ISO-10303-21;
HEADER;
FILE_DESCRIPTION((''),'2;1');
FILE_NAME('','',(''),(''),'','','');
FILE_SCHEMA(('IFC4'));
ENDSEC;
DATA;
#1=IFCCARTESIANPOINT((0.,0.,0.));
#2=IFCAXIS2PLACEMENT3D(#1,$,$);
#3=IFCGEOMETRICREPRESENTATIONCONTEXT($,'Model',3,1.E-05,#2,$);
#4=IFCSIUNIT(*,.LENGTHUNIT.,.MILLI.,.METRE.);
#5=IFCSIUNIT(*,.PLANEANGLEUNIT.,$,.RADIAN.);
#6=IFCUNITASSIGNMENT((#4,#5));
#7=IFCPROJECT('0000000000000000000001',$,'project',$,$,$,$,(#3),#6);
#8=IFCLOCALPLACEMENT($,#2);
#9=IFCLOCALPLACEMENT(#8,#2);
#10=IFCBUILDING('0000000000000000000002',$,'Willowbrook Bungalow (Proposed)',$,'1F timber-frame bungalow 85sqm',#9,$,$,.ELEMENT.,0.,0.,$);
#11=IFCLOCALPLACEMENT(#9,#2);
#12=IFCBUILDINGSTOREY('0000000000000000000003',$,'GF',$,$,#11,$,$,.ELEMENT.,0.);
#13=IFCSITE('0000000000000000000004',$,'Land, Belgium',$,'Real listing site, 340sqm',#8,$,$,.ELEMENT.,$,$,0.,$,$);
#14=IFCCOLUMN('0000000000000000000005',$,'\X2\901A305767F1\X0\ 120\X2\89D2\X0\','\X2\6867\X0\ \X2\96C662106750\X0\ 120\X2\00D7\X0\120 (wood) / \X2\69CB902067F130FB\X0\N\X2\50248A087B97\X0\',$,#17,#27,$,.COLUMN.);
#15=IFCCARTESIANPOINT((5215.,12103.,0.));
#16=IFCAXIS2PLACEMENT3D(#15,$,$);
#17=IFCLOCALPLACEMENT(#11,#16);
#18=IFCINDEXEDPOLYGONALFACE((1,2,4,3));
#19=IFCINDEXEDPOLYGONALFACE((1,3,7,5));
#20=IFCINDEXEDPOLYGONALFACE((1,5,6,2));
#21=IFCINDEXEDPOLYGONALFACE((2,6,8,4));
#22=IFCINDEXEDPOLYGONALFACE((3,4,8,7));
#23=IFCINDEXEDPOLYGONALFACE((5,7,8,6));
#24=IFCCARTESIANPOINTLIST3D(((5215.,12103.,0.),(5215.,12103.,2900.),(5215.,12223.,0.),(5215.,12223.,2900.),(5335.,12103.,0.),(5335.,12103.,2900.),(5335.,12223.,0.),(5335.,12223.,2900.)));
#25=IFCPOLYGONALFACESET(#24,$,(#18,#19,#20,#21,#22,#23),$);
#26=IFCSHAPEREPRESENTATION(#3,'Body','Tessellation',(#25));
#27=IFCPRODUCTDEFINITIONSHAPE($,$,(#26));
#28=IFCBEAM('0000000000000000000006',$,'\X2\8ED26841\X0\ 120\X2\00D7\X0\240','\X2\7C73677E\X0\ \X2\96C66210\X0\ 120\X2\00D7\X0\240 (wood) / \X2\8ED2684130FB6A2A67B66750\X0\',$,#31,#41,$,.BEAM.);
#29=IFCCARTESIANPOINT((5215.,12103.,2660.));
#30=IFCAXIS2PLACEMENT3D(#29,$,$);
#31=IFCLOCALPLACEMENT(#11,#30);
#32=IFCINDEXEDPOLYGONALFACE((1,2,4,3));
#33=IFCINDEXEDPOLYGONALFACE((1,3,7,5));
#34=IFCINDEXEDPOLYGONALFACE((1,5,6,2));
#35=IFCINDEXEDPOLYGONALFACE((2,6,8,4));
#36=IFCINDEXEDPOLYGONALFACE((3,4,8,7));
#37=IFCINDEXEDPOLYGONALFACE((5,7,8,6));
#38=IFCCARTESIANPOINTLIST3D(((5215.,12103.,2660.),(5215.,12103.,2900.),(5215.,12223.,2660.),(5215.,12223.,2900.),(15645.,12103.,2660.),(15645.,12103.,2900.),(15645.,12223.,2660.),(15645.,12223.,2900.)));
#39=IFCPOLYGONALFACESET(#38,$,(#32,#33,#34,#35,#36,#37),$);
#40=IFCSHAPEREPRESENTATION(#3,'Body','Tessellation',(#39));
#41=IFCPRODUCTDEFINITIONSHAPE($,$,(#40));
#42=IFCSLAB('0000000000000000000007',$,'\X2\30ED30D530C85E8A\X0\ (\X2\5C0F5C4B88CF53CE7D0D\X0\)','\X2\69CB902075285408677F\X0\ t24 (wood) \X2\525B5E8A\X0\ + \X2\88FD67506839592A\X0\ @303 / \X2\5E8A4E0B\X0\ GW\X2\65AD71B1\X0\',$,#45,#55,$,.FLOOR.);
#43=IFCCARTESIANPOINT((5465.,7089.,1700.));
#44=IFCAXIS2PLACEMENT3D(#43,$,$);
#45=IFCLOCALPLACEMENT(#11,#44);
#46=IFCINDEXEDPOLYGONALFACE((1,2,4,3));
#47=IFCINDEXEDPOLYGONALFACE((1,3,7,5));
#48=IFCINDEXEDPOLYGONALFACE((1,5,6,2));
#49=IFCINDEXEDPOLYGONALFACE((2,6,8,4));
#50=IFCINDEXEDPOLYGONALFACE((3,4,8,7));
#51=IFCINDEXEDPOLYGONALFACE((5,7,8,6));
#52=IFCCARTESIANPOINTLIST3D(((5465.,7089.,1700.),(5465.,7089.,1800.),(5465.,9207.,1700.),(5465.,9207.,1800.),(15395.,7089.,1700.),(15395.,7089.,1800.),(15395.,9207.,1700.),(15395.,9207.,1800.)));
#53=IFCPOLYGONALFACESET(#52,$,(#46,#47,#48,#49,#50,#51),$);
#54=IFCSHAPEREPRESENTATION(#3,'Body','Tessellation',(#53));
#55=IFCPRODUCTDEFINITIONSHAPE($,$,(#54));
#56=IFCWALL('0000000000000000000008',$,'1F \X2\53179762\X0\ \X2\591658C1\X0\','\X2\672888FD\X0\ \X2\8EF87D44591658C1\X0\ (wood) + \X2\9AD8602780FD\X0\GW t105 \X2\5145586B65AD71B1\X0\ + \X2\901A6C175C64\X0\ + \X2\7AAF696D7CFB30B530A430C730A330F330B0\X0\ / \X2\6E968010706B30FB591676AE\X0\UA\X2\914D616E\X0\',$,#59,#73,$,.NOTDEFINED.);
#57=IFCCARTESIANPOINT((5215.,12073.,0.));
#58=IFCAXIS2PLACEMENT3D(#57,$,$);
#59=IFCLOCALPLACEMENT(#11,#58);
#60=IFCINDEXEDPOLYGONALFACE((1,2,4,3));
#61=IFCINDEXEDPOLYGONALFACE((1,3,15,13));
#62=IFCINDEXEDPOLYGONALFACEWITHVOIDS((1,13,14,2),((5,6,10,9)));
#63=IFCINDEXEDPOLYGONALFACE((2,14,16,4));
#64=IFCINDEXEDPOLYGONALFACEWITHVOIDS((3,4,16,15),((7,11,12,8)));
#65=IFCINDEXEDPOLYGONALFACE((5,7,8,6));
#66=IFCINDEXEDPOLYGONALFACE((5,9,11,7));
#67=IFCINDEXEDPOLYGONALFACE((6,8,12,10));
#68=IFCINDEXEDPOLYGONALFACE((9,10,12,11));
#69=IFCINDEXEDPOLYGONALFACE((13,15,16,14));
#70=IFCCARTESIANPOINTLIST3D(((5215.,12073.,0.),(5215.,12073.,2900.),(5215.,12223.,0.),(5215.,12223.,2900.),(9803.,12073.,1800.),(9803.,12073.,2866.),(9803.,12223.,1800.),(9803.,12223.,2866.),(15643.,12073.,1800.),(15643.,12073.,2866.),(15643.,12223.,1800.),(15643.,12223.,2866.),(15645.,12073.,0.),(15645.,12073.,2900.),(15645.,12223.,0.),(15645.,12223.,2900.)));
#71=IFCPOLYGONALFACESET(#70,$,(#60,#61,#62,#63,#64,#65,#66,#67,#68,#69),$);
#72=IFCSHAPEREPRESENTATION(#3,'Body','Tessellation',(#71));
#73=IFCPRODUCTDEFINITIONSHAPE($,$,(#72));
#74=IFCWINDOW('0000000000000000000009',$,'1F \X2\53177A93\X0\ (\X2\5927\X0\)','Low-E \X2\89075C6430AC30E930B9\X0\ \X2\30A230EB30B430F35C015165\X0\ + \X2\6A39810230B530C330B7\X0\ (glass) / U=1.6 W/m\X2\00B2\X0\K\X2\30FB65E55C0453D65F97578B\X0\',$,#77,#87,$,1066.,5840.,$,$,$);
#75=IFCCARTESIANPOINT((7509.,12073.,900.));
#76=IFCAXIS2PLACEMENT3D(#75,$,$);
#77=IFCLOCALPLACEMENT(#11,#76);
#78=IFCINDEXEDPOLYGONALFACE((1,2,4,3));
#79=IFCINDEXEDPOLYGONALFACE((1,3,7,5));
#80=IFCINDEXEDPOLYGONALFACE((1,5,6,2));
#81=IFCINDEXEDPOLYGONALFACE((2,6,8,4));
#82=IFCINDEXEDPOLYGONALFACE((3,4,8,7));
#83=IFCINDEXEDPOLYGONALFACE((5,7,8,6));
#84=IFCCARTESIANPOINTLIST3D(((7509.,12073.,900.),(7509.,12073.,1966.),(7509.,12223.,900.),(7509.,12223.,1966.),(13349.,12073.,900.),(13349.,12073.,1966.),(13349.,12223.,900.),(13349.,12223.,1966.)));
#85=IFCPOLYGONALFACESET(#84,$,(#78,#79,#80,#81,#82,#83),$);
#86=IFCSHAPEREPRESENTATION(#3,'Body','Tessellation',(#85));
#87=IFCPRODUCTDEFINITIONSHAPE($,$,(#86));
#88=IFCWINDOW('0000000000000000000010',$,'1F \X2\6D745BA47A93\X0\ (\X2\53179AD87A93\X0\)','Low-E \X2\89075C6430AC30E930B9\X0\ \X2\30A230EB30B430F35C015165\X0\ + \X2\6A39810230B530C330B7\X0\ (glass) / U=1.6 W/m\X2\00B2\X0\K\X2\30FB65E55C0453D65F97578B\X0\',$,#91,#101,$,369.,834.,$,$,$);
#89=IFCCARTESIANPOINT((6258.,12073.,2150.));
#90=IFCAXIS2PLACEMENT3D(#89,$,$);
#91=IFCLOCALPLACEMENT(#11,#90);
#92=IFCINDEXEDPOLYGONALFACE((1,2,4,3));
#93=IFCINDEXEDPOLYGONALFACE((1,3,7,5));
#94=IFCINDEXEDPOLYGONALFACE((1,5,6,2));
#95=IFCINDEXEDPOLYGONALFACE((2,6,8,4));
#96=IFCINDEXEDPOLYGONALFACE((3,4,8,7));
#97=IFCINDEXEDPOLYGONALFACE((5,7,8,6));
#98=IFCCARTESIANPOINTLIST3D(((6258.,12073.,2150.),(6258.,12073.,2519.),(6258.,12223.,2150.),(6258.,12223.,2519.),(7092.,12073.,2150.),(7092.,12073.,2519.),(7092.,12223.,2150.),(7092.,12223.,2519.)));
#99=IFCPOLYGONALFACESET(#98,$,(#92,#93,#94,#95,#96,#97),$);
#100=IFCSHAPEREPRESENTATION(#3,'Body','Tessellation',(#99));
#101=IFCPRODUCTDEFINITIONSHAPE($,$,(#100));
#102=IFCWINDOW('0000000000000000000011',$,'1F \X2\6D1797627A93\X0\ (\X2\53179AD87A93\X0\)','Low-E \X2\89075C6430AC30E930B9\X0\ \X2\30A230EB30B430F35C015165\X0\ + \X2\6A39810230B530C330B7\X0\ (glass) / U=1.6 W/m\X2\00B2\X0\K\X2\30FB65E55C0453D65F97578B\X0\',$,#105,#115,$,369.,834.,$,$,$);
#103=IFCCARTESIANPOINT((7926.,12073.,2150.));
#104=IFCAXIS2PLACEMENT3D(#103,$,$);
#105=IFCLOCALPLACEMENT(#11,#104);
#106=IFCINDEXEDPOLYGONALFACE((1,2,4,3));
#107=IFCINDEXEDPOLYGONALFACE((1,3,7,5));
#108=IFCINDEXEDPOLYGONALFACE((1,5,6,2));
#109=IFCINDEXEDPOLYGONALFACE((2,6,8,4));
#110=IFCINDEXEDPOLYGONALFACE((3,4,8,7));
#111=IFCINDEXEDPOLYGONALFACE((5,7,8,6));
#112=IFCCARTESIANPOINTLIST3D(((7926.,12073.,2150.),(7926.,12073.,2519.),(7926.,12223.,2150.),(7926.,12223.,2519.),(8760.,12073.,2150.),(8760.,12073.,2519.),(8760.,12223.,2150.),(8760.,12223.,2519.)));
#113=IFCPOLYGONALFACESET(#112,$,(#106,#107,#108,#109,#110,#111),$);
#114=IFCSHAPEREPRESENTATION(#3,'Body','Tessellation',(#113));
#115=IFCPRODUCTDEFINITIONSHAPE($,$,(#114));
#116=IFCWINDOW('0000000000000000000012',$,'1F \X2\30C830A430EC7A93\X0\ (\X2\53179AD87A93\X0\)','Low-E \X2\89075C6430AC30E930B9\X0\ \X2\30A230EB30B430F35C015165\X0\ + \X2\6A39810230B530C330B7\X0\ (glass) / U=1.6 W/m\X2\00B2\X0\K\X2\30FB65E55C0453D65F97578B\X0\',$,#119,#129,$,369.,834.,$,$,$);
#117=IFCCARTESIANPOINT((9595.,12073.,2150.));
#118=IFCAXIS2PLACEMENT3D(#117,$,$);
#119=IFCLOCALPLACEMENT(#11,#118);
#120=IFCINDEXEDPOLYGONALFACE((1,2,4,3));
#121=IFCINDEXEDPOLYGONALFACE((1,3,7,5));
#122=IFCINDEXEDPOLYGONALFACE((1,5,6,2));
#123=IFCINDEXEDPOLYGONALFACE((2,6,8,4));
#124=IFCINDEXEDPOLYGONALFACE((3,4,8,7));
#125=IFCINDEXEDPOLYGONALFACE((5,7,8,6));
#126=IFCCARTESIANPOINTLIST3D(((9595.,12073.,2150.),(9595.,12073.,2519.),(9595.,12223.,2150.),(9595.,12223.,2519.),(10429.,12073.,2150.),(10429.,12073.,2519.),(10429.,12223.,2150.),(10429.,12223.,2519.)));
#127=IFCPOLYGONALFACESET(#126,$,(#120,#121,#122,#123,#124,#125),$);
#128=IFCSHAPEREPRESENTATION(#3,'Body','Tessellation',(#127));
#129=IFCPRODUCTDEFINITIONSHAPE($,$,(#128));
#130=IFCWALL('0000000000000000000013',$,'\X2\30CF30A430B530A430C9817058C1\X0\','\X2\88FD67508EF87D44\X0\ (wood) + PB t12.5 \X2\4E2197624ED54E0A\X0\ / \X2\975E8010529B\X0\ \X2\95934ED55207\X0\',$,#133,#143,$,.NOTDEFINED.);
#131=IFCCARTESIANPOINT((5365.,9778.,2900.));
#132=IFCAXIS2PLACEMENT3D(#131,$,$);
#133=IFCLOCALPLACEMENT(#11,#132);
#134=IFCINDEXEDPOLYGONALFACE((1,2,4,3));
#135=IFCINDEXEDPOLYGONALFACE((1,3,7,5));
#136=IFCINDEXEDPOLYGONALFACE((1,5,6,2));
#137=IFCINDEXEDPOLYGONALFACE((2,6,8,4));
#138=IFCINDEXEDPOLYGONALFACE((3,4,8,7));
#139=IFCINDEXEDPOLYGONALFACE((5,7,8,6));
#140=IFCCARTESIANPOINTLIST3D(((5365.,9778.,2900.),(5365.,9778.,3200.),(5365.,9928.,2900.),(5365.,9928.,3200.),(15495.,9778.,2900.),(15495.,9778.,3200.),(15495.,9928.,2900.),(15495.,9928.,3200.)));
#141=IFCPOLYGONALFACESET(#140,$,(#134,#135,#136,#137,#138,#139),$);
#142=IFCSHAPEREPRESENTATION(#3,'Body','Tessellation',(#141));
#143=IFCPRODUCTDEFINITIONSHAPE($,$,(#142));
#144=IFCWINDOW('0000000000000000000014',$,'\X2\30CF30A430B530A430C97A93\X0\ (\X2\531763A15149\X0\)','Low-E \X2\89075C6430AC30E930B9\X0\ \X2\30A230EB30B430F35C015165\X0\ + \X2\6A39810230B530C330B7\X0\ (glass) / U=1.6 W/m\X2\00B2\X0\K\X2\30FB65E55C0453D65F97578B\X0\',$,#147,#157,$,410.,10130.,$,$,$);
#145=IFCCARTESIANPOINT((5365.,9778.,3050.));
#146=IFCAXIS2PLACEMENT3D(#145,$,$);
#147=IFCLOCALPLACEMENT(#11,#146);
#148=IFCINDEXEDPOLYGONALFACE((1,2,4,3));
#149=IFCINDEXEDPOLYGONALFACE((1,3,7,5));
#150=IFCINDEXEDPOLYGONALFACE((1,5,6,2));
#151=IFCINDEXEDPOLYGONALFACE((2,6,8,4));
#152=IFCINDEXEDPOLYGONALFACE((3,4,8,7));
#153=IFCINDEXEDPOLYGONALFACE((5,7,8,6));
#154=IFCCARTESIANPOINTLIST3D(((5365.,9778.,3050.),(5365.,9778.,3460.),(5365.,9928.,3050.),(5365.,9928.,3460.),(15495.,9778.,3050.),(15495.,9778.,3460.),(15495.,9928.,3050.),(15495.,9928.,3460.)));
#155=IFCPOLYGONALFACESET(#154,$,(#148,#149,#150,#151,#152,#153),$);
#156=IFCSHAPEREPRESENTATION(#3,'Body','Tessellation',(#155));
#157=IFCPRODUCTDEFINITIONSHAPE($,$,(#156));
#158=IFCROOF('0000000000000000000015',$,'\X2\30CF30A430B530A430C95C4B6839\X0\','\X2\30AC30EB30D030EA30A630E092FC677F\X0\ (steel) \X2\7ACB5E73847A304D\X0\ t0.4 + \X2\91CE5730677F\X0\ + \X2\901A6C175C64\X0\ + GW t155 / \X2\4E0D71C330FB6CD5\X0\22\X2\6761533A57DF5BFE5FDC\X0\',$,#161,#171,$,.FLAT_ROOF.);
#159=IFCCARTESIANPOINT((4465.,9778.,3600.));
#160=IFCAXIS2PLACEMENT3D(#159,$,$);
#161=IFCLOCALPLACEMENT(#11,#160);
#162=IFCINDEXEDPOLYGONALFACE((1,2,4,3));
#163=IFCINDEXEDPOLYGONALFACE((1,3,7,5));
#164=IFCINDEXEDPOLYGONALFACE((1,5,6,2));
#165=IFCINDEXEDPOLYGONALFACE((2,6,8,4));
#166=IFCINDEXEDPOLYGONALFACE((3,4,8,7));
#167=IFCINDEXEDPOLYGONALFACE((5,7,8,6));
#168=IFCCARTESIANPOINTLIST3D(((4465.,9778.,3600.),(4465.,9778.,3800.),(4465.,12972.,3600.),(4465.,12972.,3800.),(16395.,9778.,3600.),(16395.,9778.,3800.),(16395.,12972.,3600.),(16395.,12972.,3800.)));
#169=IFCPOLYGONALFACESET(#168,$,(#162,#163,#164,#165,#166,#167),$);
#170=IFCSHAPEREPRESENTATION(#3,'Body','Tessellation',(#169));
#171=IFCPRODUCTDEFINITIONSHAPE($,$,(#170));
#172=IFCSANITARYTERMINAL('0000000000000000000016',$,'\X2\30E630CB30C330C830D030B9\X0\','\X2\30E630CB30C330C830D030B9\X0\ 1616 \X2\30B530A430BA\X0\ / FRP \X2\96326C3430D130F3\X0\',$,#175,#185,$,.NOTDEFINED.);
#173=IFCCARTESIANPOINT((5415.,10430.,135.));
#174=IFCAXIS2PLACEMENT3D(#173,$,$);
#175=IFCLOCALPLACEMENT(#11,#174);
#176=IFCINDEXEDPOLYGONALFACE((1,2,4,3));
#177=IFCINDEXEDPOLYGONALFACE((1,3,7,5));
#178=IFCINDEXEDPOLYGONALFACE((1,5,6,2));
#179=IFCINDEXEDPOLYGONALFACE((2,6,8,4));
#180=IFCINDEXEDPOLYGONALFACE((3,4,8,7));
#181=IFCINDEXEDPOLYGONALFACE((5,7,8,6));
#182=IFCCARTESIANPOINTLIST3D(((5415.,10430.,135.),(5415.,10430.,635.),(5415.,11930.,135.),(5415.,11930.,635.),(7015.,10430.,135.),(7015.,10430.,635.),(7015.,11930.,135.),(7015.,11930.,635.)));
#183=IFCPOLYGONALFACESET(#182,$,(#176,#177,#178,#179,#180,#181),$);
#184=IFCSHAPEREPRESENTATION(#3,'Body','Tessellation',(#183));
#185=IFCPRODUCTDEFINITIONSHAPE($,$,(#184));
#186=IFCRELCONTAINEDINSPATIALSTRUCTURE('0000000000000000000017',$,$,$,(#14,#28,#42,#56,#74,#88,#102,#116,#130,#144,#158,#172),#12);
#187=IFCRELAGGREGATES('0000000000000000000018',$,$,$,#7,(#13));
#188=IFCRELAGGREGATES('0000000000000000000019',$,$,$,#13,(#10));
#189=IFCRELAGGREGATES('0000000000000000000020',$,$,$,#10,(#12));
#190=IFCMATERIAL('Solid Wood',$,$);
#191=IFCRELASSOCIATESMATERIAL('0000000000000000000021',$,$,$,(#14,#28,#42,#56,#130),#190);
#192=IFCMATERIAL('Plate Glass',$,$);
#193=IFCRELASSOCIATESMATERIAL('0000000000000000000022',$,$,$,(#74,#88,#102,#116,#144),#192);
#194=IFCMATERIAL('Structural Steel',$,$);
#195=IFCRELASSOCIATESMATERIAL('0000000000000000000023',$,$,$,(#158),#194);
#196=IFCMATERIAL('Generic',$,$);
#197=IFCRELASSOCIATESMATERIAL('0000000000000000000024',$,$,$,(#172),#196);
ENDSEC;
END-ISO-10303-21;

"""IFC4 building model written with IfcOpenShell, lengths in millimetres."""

from ifc_helpers import new_model, si_unit, frame, frame_2d, origin, place, context, project, spatial, rectangle, extrude, material, element, fill, save


model = new_model("IFC4")

# Units and contexts
model_context = context("Model", 3, precision=1e-05, world=origin())
ifc_project = project(units=[si_unit("LENGTHUNIT", "METRE", prefix="MILLI"), si_unit("PLANEANGLEUNIT", "RADIAN")], contexts=[model_context])

# Site, building, storey
site_placement = place(None, origin())
site = spatial("IfcSite", under=ifc_project, at=site_placement, Name="Land, Belgium", ObjectType="Real listing site, 340sqm", CompositionType="ELEMENT", RefElevation=0.0)
building_placement = place(site_placement, origin())
building = spatial("IfcBuilding", under=site, at=building_placement, Name="Willowbrook Bungalow (Proposed)", ObjectType="1F timber-frame bungalow 85sqm", CompositionType="ELEMENT", ElevationOfRefHeight=0.0, ElevationOfTerrain=0.0)
storey_placement = place(building_placement, origin())
storey = spatial("IfcBuildingStorey", under=building, at=storey_placement, Name="GF", CompositionType="ELEMENT", Elevation=0.0)

# Column
ifc_material_1 = material(Name="Solid Wood")
column_1_placement = place(storey_placement, frame((5215.0, 12103.0, 0.0)))
element("IfcColumn", 1, at=column_1_placement, inside=storey, material=ifc_material_1, Name="通し柱 120角", Description="桧 集成材 120×120 (wood) / 構造柱・N値計算", PredefinedType="COLUMN", context=model_context, shape_type="SweptSolid", body=[
    extrude(rectangle(XDim=120.0, YDim=120.0, at=frame_2d((60.0, 60.0))), frame((5215.0, 12103.0, 0.0)), (0.0, 0.0, 1.0), 2900.0),
])

# Beam
beam_1_placement = place(storey_placement, frame((5215.0, 12103.0, 2660.0)))
element("IfcBeam", 2, at=beam_1_placement, inside=storey, material=ifc_material_1, Name="軒桁 120×240", Description="米松 集成 120×240 (wood) / 軒桁・横架材", PredefinedType="BEAM", context=model_context, shape_type="SweptSolid", body=[
    extrude(rectangle(XDim=10430.0, YDim=120.0, at=frame_2d((5215.0, 60.0))), frame((5215.0, 12103.0, 2660.0)), (0.0, 0.0, 1.0), 240.0),
])

# Slab
slab_placement = place(storey_placement, frame((5465.0, 7089.0, 1700.0)))
element("IfcSlab", 3, at=slab_placement, inside=storey, material=ifc_material_1, Name="ロフト床 (小屋裏収納)", Description="構造用合板 t24 (wood) 剛床 + 製材根太 @303 / 床下 GW断熱", PredefinedType="FLOOR", context=model_context, shape_type="SweptSolid", body=[
    extrude(rectangle(XDim=9930.0, YDim=2118.0, at=frame_2d((4965.0, 1059.0))), frame((5465.0, 7089.0, 1700.0)), (0.0, 0.0, 1.0), 100.0),
])

# Wall, openings, windows
wall_1_placement = place(storey_placement, frame((5215.0, 12073.0, 0.0)))
wall_1 = element("IfcWall", 4, at=wall_1_placement, inside=storey, material=ifc_material_1, Name="1F 北面 外壁", Description="木製 軸組外壁 (wood) + 高性能GW t105 充填断熱 + 通気層 + 窯業系サイディング / 準耐火・外皮UA配慮", PredefinedType="NOTDEFINED", context=model_context, shape_type="SweptSolid", body=[
    extrude(rectangle(XDim=10430.0, YDim=150.0, at=frame_2d((5215.0, 75.0))), frame((5215.0, 12073.0, 0.0)), (0.0, 0.0, 1.0), 2900.0),
])
opening_1_placement = place(storey_placement, frame((7509.0, 12073.0, 900.0)))
opening_1 = element("IfcOpeningElement", 5, at=opening_1_placement, cuts=wall_1, PredefinedType="NOTDEFINED", context=model_context, shape_type="SweptSolid", body=[
    extrude(rectangle(XDim=5840.0, YDim=150.0, at=frame_2d((2920.0, 75.0))), frame((7509.0, 12073.0, 900.0)), (0.0, 0.0, 1.0), 1066.0),
])
opening_2_placement = place(storey_placement, frame((6258.0, 12073.0, 2150.0)))
opening_2 = element("IfcOpeningElement", 6, at=opening_2_placement, cuts=wall_1, PredefinedType="NOTDEFINED", context=model_context, shape_type="SweptSolid", body=[
    extrude(rectangle(XDim=834.0, YDim=150.0, at=frame_2d((417.0, 75.0))), frame((6258.0, 12073.0, 2150.0)), (0.0, 0.0, 1.0), 369.0),
])
opening_3_placement = place(storey_placement, frame((7926.0, 12073.0, 2150.0)))
opening_3 = element("IfcOpeningElement", 7, at=opening_3_placement, cuts=wall_1, PredefinedType="NOTDEFINED", context=model_context, shape_type="SweptSolid", body=[
    extrude(rectangle(XDim=834.0, YDim=150.0, at=frame_2d((417.0, 75.0))), frame((7926.0, 12073.0, 2150.0)), (0.0, 0.0, 1.0), 369.0),
])
opening_4_placement = place(storey_placement, frame((9595.0, 12073.0, 2150.0)))
opening_4 = element("IfcOpeningElement", 8, at=opening_4_placement, cuts=wall_1, PredefinedType="NOTDEFINED", context=model_context, shape_type="SweptSolid", body=[
    extrude(rectangle(XDim=834.0, YDim=150.0, at=frame_2d((417.0, 75.0))), frame((9595.0, 12073.0, 2150.0)), (0.0, 0.0, 1.0), 369.0),
])
ifc_material_2 = material(Name="Plate Glass")
window_1_placement = place(storey_placement, frame((7509.0, 12073.0, 900.0)))
window_1 = element("IfcWindow", 9, at=window_1_placement, inside=storey, material=ifc_material_2, Name="1F 北窓 (大)", Description="Low-E 複層ガラス アルゴン封入 + 樹脂サッシ (glass) / U=1.6 W/m²K・日射取得型", OverallHeight=1066.0, OverallWidth=5840.0, context=model_context, shape_type="SweptSolid", body=[
    extrude(rectangle(XDim=5840.0, YDim=150.0, at=frame_2d((2920.0, 75.0))), frame((7509.0, 12073.0, 900.0)), (0.0, 0.0, 1.0), 1066.0),
])
fill(opening_1, window_1)
window_2_placement = place(storey_placement, frame((6258.0, 12073.0, 2150.0)))
window_2 = element("IfcWindow", 10, at=window_2_placement, inside=storey, material=ifc_material_2, Name="1F 浴室窓 (北高窓)", Description="Low-E 複層ガラス アルゴン封入 + 樹脂サッシ (glass) / U=1.6 W/m²K・日射取得型", OverallHeight=369.0, OverallWidth=834.0, context=model_context, shape_type="SweptSolid", body=[
    extrude(rectangle(XDim=834.0, YDim=150.0, at=frame_2d((417.0, 75.0))), frame((6258.0, 12073.0, 2150.0)), (0.0, 0.0, 1.0), 369.0),
])
fill(opening_2, window_2)
window_3_placement = place(storey_placement, frame((7926.0, 12073.0, 2150.0)))
window_3 = element("IfcWindow", 11, at=window_3_placement, inside=storey, material=ifc_material_2, Name="1F 洗面窓 (北高窓)", Description="Low-E 複層ガラス アルゴン封入 + 樹脂サッシ (glass) / U=1.6 W/m²K・日射取得型", OverallHeight=369.0, OverallWidth=834.0, context=model_context, shape_type="SweptSolid", body=[
    extrude(rectangle(XDim=834.0, YDim=150.0, at=frame_2d((417.0, 75.0))), frame((7926.0, 12073.0, 2150.0)), (0.0, 0.0, 1.0), 369.0),
])
fill(opening_3, window_3)
window_4_placement = place(storey_placement, frame((9595.0, 12073.0, 2150.0)))
window_4 = element("IfcWindow", 12, at=window_4_placement, inside=storey, material=ifc_material_2, Name="1F トイレ窓 (北高窓)", Description="Low-E 複層ガラス アルゴン封入 + 樹脂サッシ (glass) / U=1.6 W/m²K・日射取得型", OverallHeight=369.0, OverallWidth=834.0, context=model_context, shape_type="SweptSolid", body=[
    extrude(rectangle(XDim=834.0, YDim=150.0, at=frame_2d((417.0, 75.0))), frame((9595.0, 12073.0, 2150.0)), (0.0, 0.0, 1.0), 369.0),
])
fill(opening_4, window_4)

# Wall, opening, window
wall_2_placement = place(storey_placement, frame((5365.0, 9778.0, 2900.0)))
wall_2 = element("IfcWall", 13, at=wall_2_placement, inside=storey, material=ifc_material_1, Name="ハイサイド腰壁", Description="製材軸組 (wood) + PB t12.5 両面仕上 / 非耐力 間仕切", PredefinedType="NOTDEFINED", context=model_context, shape_type="SweptSolid", body=[
    extrude(rectangle(XDim=10130.0, YDim=150.0, at=frame_2d((5065.0, 75.0))), frame((5365.0, 9778.0, 2900.0)), (0.0, 0.0, 1.0), 700.0),
])
opening_5_placement = place(storey_placement, frame((5365.0, 9778.0, 3050.0)))
opening_5 = element("IfcOpeningElement", 14, at=opening_5_placement, cuts=wall_2, PredefinedType="NOTDEFINED", context=model_context, shape_type="SweptSolid", body=[
    extrude(rectangle(XDim=10130.0, YDim=150.0, at=frame_2d((5065.0, 75.0))), frame((5365.0, 9778.0, 3050.0)), (0.0, 0.0, 1.0), 410.0),
])
window_5_placement = place(storey_placement, frame((5365.0, 9778.0, 3050.0)))
window_5 = element("IfcWindow", 15, at=window_5_placement, inside=storey, material=ifc_material_2, Name="ハイサイド窓 (北採光)", Description="Low-E 複層ガラス アルゴン封入 + 樹脂サッシ (glass) / U=1.6 W/m²K・日射取得型", OverallHeight=410.0, OverallWidth=10130.0, context=model_context, shape_type="SweptSolid", body=[
    extrude(rectangle(XDim=10130.0, YDim=150.0, at=frame_2d((5065.0, 75.0))), frame((5365.0, 9778.0, 3050.0)), (0.0, 0.0, 1.0), 410.0),
])
fill(opening_5, window_5)

# Roof
ifc_material_3 = material(Name="Structural Steel")
roof_placement = place(storey_placement, frame((4465.0, 9778.0, 3600.0)))
element("IfcRoof", 16, at=roof_placement, inside=storey, material=ifc_material_3, Name="ハイサイド屋根", Description="ガルバリウム鋼板 (steel) 立平葺き t0.4 + 野地板 + 通気層 + GW t155 / 不燃・法22条区域対応", PredefinedType="FLAT_ROOF", context=model_context, shape_type="SweptSolid", body=[
    extrude(rectangle(XDim=11930.0, YDim=3194.0, at=frame_2d((5965.0, 1597.0))), frame((4465.0, 9778.0, 3600.0)), (0.0, 0.0, 1.0), 200.0),
])

# Sanitary terminal
ifc_material_4 = material(Name="Generic")
sanitary_terminal_placement = place(storey_placement, frame((5415.0, 10430.0, 135.0)))
element("IfcSanitaryTerminal", 17, at=sanitary_terminal_placement, inside=storey, material=ifc_material_4, Name="ユニットバス", Description="ユニットバス 1616 サイズ / FRP 防水パン", PredefinedType="NOTDEFINED", context=model_context, shape_type="SweptSolid", body=[
    extrude(rectangle(XDim=1600.0, YDim=1500.0, at=frame_2d((800.0, 750.0))), frame((5415.0, 10430.0, 135.0)), (0.0, 0.0, 1.0), 500.0),
])

save(model, "model.ifc")
